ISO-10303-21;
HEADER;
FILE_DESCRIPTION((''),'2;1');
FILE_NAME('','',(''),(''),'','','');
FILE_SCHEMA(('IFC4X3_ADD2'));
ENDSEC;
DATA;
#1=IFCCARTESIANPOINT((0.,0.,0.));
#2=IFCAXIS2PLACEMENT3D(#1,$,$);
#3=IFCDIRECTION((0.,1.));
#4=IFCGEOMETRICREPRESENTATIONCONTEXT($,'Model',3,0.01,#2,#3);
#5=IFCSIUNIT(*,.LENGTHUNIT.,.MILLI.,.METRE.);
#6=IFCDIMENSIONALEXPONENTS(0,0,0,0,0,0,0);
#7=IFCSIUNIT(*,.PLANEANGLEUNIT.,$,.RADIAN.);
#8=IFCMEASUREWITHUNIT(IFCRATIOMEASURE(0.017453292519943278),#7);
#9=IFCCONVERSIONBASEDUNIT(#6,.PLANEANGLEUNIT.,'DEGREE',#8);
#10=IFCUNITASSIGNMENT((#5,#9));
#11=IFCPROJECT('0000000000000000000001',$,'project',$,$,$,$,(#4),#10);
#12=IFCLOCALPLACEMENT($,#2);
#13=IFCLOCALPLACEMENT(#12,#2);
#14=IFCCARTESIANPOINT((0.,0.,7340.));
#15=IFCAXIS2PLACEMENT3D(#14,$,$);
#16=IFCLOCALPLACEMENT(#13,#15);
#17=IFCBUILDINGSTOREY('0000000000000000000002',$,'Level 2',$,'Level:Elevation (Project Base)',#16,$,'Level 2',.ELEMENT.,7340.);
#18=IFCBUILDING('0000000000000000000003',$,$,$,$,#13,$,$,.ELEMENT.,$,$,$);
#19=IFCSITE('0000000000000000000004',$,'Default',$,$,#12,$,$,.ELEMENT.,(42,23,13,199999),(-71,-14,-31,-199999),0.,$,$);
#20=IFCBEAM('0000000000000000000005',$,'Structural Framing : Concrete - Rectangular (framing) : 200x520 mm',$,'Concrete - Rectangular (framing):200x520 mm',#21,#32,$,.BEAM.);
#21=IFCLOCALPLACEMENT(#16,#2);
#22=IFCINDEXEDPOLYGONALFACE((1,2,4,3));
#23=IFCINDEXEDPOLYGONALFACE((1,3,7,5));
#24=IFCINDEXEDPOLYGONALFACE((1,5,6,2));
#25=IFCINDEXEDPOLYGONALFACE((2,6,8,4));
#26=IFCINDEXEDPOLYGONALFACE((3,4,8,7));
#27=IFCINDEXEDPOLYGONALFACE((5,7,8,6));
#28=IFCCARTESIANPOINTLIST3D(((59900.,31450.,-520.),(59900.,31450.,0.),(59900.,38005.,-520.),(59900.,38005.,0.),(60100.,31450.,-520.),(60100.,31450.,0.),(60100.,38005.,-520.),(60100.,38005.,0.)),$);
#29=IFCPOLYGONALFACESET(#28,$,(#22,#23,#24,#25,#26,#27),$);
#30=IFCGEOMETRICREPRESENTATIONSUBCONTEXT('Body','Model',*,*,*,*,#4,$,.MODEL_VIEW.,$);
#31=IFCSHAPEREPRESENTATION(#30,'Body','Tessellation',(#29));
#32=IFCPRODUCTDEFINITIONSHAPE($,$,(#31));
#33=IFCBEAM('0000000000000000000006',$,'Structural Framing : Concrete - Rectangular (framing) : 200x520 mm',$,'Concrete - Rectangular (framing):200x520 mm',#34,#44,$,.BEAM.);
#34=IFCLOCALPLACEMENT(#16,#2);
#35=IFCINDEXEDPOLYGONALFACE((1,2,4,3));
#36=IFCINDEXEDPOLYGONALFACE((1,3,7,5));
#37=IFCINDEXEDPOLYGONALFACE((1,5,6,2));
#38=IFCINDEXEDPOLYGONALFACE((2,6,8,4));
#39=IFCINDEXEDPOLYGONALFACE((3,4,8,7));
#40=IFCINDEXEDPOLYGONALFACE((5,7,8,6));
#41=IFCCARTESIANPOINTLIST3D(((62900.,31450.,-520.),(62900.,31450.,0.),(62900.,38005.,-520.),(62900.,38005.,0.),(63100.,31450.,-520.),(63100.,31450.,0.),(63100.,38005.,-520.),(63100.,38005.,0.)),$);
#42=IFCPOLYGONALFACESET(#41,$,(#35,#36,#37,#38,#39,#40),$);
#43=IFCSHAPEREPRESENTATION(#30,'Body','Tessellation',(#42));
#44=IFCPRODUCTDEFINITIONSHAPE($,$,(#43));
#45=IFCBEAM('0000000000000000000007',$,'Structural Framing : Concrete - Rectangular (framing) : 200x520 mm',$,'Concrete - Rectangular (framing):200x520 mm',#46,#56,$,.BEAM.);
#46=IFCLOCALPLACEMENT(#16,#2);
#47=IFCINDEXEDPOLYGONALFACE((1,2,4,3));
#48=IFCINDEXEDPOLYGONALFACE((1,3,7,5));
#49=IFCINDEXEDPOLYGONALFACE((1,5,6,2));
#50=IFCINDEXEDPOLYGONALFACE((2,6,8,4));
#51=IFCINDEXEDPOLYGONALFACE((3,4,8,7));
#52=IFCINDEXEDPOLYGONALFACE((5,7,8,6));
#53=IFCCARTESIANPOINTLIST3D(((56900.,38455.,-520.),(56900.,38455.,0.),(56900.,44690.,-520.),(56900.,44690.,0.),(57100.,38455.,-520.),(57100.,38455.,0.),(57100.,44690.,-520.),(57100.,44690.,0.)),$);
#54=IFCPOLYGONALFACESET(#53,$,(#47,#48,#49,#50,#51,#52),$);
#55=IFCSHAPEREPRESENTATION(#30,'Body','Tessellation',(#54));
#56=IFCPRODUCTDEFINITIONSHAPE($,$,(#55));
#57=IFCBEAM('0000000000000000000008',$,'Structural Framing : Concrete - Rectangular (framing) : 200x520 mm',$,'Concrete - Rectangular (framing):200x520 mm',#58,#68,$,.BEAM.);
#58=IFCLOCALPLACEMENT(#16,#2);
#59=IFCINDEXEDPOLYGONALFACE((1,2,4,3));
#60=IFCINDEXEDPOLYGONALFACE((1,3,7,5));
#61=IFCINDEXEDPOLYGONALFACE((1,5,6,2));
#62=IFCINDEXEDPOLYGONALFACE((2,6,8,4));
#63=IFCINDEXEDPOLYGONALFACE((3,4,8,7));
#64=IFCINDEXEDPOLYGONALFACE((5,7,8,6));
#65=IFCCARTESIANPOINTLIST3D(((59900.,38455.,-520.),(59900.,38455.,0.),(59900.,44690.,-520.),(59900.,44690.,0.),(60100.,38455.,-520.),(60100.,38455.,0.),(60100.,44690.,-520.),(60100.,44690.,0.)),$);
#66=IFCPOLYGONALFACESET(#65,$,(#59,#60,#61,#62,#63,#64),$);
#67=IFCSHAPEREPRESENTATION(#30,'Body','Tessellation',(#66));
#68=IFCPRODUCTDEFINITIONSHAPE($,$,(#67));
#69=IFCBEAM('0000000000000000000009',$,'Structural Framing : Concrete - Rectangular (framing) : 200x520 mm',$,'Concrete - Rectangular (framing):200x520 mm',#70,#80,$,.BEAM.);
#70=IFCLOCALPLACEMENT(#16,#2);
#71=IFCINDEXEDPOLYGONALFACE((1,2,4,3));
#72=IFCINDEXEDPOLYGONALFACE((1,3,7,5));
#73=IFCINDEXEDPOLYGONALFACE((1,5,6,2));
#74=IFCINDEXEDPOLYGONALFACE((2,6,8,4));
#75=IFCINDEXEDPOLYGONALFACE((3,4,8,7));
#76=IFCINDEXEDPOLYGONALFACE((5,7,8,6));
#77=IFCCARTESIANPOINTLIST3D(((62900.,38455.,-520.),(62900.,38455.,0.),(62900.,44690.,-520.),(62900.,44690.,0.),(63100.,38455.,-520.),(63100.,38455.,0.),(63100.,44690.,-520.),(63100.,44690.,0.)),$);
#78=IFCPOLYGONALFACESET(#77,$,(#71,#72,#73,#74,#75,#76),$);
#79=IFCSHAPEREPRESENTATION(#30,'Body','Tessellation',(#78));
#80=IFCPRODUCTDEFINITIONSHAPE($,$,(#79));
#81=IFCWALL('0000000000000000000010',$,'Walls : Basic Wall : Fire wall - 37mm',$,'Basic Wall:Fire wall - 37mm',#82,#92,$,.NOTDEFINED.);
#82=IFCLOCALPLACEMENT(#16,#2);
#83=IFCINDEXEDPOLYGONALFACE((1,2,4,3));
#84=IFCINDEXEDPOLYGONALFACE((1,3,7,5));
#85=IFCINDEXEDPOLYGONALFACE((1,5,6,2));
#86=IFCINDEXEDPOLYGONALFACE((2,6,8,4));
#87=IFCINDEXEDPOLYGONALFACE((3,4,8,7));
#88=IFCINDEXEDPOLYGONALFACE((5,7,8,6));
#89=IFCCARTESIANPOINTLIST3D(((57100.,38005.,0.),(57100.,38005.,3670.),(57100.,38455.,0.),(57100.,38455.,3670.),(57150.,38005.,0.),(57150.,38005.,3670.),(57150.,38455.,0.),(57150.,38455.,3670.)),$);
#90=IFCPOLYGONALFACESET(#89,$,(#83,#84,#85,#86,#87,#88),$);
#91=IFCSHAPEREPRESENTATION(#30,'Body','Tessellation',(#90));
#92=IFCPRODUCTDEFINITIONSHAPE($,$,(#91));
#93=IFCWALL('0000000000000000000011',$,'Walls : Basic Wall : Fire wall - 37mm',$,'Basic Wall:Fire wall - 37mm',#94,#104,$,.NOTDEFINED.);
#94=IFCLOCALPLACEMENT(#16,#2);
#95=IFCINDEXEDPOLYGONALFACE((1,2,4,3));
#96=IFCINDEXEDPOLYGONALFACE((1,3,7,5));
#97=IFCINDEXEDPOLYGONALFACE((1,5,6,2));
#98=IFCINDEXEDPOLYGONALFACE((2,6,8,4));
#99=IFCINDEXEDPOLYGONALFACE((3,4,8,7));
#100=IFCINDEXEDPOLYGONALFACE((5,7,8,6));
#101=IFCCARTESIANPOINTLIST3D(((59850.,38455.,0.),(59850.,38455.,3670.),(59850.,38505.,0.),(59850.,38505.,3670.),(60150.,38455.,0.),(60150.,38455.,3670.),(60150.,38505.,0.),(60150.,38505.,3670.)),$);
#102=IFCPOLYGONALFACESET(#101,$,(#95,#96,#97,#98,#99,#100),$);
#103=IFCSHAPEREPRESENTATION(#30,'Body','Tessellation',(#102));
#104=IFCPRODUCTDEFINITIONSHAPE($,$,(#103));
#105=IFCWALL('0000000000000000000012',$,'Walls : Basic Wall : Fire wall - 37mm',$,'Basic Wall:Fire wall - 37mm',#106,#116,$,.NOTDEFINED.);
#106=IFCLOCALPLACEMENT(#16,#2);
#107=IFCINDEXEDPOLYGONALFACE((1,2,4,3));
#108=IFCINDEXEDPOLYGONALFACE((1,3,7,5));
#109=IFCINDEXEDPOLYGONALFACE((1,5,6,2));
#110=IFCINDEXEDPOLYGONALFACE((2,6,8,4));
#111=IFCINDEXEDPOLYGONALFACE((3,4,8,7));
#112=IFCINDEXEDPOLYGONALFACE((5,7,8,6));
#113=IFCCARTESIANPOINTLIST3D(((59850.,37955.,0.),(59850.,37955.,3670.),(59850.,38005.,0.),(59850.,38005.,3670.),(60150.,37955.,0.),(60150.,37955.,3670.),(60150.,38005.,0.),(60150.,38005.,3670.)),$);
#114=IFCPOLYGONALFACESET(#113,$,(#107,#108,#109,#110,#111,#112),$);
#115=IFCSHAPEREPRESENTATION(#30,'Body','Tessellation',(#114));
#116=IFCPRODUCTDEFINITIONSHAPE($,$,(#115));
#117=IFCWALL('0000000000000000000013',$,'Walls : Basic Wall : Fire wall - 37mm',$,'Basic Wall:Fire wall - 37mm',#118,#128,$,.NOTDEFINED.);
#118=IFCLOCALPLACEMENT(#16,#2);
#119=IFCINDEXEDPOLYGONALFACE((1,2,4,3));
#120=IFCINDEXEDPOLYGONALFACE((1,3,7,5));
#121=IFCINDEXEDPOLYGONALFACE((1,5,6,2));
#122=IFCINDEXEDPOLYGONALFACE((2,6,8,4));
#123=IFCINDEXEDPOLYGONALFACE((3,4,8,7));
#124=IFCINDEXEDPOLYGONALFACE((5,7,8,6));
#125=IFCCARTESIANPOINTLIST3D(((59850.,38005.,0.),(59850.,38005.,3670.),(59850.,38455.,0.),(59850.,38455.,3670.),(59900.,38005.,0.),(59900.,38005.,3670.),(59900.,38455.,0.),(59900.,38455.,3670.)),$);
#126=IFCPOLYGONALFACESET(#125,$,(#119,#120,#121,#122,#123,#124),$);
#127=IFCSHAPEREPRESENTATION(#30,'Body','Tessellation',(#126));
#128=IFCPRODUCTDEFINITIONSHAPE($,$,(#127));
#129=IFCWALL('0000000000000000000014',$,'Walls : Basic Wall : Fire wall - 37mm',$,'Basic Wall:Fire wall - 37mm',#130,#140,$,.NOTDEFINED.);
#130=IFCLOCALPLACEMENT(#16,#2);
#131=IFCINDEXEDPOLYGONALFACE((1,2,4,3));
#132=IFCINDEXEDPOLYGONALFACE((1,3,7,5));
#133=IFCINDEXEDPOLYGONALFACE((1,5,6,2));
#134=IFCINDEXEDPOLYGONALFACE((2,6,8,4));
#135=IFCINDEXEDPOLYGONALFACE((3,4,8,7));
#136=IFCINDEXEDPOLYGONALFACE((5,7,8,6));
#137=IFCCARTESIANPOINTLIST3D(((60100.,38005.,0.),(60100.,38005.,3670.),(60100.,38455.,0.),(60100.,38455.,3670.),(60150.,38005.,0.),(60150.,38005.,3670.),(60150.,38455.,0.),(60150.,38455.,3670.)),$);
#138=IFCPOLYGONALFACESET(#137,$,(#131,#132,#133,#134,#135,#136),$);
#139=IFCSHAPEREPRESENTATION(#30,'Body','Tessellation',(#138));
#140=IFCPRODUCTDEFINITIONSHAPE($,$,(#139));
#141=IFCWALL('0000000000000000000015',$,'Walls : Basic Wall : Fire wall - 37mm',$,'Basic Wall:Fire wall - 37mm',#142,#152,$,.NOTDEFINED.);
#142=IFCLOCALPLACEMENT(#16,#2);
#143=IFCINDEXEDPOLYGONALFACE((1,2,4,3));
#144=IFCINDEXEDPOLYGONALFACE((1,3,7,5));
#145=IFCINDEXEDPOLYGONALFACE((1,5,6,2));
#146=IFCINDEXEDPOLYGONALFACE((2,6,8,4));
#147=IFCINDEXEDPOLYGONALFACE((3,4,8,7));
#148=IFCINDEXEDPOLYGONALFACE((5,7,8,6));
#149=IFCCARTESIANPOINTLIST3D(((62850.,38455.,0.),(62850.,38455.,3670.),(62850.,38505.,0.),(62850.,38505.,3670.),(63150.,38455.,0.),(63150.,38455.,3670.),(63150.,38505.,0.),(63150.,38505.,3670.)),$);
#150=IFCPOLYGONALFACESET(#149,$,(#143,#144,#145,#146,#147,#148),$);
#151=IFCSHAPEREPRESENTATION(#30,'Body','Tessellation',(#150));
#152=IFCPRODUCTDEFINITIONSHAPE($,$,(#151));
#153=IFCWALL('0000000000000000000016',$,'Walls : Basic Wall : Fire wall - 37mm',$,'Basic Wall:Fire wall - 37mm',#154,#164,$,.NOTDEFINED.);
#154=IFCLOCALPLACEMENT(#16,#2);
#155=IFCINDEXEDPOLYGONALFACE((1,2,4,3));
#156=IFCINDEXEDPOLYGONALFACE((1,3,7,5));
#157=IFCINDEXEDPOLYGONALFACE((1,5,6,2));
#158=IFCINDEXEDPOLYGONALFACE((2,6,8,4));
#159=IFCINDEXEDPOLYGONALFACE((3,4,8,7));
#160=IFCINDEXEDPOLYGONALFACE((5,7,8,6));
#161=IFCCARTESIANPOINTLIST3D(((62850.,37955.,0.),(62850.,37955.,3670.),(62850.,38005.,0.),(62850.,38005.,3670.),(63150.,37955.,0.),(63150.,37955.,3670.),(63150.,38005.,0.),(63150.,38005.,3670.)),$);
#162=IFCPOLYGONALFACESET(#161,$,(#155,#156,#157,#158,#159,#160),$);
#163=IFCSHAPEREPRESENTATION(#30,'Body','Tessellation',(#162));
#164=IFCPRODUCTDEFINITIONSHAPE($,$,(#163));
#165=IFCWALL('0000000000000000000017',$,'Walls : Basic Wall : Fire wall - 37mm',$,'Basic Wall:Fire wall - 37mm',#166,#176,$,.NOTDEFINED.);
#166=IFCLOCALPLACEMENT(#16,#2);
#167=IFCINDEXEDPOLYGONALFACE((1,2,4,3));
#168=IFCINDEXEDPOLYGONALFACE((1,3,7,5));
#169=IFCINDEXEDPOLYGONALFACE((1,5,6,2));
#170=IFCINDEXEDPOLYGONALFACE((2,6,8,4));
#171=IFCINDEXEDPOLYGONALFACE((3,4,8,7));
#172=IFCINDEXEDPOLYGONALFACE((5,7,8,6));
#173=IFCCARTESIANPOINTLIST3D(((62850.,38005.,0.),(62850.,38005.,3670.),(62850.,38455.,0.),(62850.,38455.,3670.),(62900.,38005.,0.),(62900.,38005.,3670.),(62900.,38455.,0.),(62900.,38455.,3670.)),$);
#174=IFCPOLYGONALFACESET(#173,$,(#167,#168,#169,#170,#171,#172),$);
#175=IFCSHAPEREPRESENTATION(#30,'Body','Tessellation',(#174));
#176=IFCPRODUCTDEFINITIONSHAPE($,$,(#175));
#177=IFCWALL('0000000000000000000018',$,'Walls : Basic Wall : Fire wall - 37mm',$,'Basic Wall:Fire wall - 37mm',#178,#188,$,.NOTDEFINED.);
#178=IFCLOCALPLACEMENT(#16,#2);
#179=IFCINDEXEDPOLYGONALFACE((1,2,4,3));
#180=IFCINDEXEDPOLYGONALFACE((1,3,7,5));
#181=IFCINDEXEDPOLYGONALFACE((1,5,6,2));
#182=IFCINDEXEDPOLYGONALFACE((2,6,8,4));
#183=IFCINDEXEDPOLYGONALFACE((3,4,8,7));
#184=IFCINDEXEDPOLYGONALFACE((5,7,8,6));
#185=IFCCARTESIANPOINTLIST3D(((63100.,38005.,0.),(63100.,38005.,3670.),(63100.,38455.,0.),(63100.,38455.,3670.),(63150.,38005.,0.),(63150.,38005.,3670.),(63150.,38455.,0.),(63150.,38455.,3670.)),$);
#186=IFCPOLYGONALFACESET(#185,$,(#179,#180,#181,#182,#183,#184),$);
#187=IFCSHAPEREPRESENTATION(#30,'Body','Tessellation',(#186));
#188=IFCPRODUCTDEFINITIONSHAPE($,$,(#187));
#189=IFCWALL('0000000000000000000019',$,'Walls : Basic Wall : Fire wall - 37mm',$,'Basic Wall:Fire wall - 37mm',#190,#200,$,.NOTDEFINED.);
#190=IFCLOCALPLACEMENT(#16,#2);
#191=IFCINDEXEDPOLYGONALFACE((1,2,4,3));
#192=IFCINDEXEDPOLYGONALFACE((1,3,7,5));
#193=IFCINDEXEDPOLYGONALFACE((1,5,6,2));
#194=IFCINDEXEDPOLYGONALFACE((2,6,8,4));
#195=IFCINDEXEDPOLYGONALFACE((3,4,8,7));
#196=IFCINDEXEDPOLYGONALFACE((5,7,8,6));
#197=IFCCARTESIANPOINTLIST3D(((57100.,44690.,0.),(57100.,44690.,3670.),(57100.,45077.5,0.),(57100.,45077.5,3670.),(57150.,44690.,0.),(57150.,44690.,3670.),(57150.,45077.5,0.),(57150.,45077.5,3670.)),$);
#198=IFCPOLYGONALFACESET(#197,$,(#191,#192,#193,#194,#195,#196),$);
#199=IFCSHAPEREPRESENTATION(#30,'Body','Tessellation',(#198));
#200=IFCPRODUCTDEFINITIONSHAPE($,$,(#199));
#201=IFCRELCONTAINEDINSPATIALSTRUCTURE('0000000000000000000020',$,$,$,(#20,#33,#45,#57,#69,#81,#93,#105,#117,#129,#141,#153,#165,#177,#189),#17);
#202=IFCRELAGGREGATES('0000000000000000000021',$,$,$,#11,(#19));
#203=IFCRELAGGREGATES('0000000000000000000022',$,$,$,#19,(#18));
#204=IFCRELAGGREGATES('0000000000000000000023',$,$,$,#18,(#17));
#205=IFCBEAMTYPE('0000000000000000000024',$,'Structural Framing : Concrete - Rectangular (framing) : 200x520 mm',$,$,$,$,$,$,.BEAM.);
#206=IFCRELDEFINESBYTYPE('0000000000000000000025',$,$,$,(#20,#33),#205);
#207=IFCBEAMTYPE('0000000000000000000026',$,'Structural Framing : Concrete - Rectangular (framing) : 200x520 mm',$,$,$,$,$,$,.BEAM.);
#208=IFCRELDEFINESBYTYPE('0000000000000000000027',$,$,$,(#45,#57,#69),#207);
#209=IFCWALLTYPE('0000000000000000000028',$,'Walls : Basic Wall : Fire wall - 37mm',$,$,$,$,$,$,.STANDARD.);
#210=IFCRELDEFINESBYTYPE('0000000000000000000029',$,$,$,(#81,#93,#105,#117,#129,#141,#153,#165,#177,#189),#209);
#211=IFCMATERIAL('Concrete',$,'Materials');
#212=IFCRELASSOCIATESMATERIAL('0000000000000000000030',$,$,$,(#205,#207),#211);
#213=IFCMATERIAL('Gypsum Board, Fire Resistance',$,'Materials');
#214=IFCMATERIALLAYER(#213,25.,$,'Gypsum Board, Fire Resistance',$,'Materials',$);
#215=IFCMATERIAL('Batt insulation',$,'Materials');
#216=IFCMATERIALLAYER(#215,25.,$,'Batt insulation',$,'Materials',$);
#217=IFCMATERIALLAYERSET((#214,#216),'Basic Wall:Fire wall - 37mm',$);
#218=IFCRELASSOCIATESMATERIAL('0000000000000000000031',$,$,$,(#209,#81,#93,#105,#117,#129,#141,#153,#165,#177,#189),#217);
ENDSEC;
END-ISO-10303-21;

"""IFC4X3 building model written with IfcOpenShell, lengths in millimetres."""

from ifc_helpers import new_model, entity, si_unit, converted_unit, direction, frame, frame_2d, origin, place, context, subcontext, project, spatial, rectangle, extrude, source, transform, mapped, material, layer, layer_set, material_profile, profile_set, type_object, type_shapes, element, save


model = new_model("IFC4X3")

# Units and contexts
model_context = context("Model", 3, precision=0.01, world=origin(), true_north=direction((0.0, 1.0)))
body_context = subcontext(model_context, "Body", "Model", "MODEL_VIEW")
ifc_project = project(units=[si_unit("LENGTHUNIT", "METRE", prefix="MILLI"), converted_unit("PLANEANGLEUNIT", "DEGREE", entity("IfcRatioMeasure", 0.017453292519943278), si_unit("PLANEANGLEUNIT", "RADIAN"), dimensions=[0, 0, 0, 0, 0, 0, 0])], contexts=[model_context])

# Site, building, storey
site_placement = place(None, origin())
site = spatial("IfcSite", under=ifc_project, at=site_placement, Name="Default", CompositionType="ELEMENT", RefLatitude=(42, 23, 13, 199999), RefLongitude=(-71, -14, -31, -199999), RefElevation=0.0)
building_placement = place(site_placement, origin())
building = spatial("IfcBuilding", under=site, at=building_placement, CompositionType="ELEMENT")
storey_placement = place(building_placement, frame((0.0, 0.0, 7340.0)))
storey = spatial("IfcBuildingStorey", under=building, at=storey_placement, Name="Level 2", ObjectType="Level:Elevation (Project Base)", LongName="Level 2", CompositionType="ELEMENT", Elevation=7340.0)

# Beams
ifc_material_1 = material(Name="Concrete", Category="Materials")
ifc_material_profile = material_profile(ifc_material_1, rectangle(XDim=520.0, YDim=200.0, at=frame_2d((0.0, 0.0), x_axis=(1.0, 0.0))), Name="200x520 mm")
ifc_profile_set = profile_set([ifc_material_profile], Name="200x520 mm")
beam_type_1 = type_object("IfcBeamType", Name="Structural Framing : Concrete - Rectangular (framing) : 200x520 mm", PredefinedType="BEAM", material=ifc_profile_set)
shared_shape_1 = source(origin(), body_context, "Body", "SweptSolid", [
    extrude(rectangle(XDim=520.0, YDim=200.0, at=frame_2d((0.0, 0.0), x_axis=(1.0, 0.0))), frame((-1165.0, 0.0, 0.0), z_axis=(1.0, 0.0, 0.0), x_axis=(0.0, 0.0, -1.0)), (0.0, 0.0, 1.0), 6555.0),
])
type_shapes(beam_type_1, [shared_shape_1])
for number, where, z_axis, x_axis, name in (
    (1, (60000.0, 36840.0, -260.0), (0.0, 0.0, 1.0), (0.0, -1.0, 0.0), "Structural Framing : Concrete - Rectangular (framing) : 200x520 mm"),
    (2, (63000.0, 36840.0, -260.0), (0.0, 0.0, 1.0), (0.0, -1.0, 0.0), "Structural Framing : Concrete - Rectangular (framing) : 200x520 mm"),
):
    element("IfcBeam", number, at=place(storey_placement, frame(where, z_axis=z_axis, x_axis=x_axis)), inside=storey, type_object=beam_type_1, Name=name, ObjectType="Concrete - Rectangular (framing):200x520 mm", PredefinedType="BEAM", context=body_context, shape_type="MappedRepresentation", body=[
        mapped(shared_shape_1, transform((0.0, 0.0, 0.0), scale=1.0)),
    ])
beam_type_2 = type_object("IfcBeamType", Name="Structural Framing : Concrete - Rectangular (framing) : 200x520 mm", PredefinedType="BEAM", material=ifc_profile_set)
shared_shape_2 = source(origin(), body_context, "Body", "SweptSolid", [
    extrude(rectangle(XDim=520.0, YDim=200.0, at=frame_2d((0.0, 0.0), x_axis=(1.0, 0.0))), frame((-1350.0, 0.0, 0.0), z_axis=(1.0, 0.0, 0.0), x_axis=(0.0, 0.0, -1.0)), (0.0, 0.0, 1.0), 6235.0),
])
type_shapes(beam_type_2, [shared_shape_2])
for number, where, z_axis, x_axis, name in (
    (3, (57000.0, 43340.0, -260.0), (0.0, 0.0, 1.0), (0.0, -1.0, 0.0), "Structural Framing : Concrete - Rectangular (framing) : 200x520 mm"),
    (4, (60000.0, 43340.0, -260.0), (0.0, 0.0, 1.0), (0.0, -1.0, 0.0), "Structural Framing : Concrete - Rectangular (framing) : 200x520 mm"),
    (5, (63000.0, 43340.0, -260.0), (0.0, 0.0, 1.0), (0.0, -1.0, 0.0), "Structural Framing : Concrete - Rectangular (framing) : 200x520 mm"),
):
    element("IfcBeam", number, at=place(storey_placement, frame(where, z_axis=z_axis, x_axis=x_axis)), inside=storey, type_object=beam_type_2, Name=name, ObjectType="Concrete - Rectangular (framing):200x520 mm", PredefinedType="BEAM", context=body_context, shape_type="MappedRepresentation", body=[
        mapped(shared_shape_2, transform((0.0, 0.0, 0.0), scale=1.0)),
    ])

# Walls
ifc_material_2 = material(Name="Gypsum Board, Fire Resistance", Category="Materials")
ifc_layer_1 = layer(ifc_material_2, 25.0, Name="Gypsum Board, Fire Resistance", Category="Materials")
ifc_material_3 = material(Name="Batt insulation", Category="Materials")
ifc_layer_2 = layer(ifc_material_3, 25.0, Name="Batt insulation", Category="Materials")
ifc_layer_set = layer_set([ifc_layer_1, ifc_layer_2], Name="Basic Wall:Fire wall - 37mm")
wall_type = type_object("IfcWallType", Name="Walls : Basic Wall : Fire wall - 37mm", PredefinedType="STANDARD", material=ifc_layer_set)
wall_1_placement = place(storey_placement, frame((57125.0, 38455.0, 0.0), z_axis=(0.0, 0.0, 1.0), x_axis=(0.0, -1.0, 0.0)))
element("IfcWall", 6, at=wall_1_placement, inside=storey, type_object=wall_type, material=ifc_layer_set, Name="Walls : Basic Wall : Fire wall - 37mm", ObjectType="Basic Wall:Fire wall - 37mm", PredefinedType="NOTDEFINED", context=body_context, shape_type="SweptSolid", body=[
    extrude(rectangle(XDim=450.0, YDim=50.0, at=frame_2d((225.0, 0.0), x_axis=(-1.0, 0.0))), origin(), (0.0, 0.0, 1.0), 3670.0),
])
for number, where, name in (
    (7, (59850.0, 38480.0, 0.0), "Walls : Basic Wall : Fire wall - 37mm"),
    (8, (59850.0, 37980.0, 0.0), "Walls : Basic Wall : Fire wall - 37mm"),
):
    element("IfcWall", number, at=place(storey_placement, frame(where)), inside=storey, type_object=wall_type, material=ifc_layer_set, Name=name, ObjectType="Basic Wall:Fire wall - 37mm", PredefinedType="NOTDEFINED", context=body_context, shape_type="SweptSolid", body=[
        extrude(rectangle(XDim=300.0, YDim=50.0, at=frame_2d((150.0, 0.0), x_axis=(-1.0, 0.0))), origin(), (0.0, 0.0, 1.0), 3670.0),
    ])
for number, where, z_axis, x_axis, name in (
    (9, (59875.0, 38455.0, 0.0), (0.0, 0.0, 1.0), (0.0, -1.0, 0.0), "Walls : Basic Wall : Fire wall - 37mm"),
    (10, (60125.0, 38455.0, 0.0), (0.0, 0.0, 1.0), (0.0, -1.0, 0.0), "Walls : Basic Wall : Fire wall - 37mm"),
):
    element("IfcWall", number, at=place(storey_placement, frame(where, z_axis=z_axis, x_axis=x_axis)), inside=storey, type_object=wall_type, material=ifc_layer_set, Name=name, ObjectType="Basic Wall:Fire wall - 37mm", PredefinedType="NOTDEFINED", context=body_context, shape_type="SweptSolid", body=[
        extrude(rectangle(XDim=450.0, YDim=50.0, at=frame_2d((225.0, 0.0), x_axis=(-1.0, 0.0))), origin(), (0.0, 0.0, 1.0), 3670.0),
    ])
for number, where, name in (
    (11, (62850.0, 38480.0, 0.0), "Walls : Basic Wall : Fire wall - 37mm"),
    (12, (62850.0, 37980.0, 0.0), "Walls : Basic Wall : Fire wall - 37mm"),
):
    element("IfcWall", number, at=place(storey_placement, frame(where)), inside=storey, type_object=wall_type, material=ifc_layer_set, Name=name, ObjectType="Basic Wall:Fire wall - 37mm", PredefinedType="NOTDEFINED", context=body_context, shape_type="SweptSolid", body=[
        extrude(rectangle(XDim=300.0, YDim=50.0, at=frame_2d((150.0, 0.0), x_axis=(-1.0, 0.0))), origin(), (0.0, 0.0, 1.0), 3670.0),
    ])
for number, where, z_axis, x_axis, name in (
    (13, (62875.0, 38455.0, 0.0), (0.0, 0.0, 1.0), (0.0, -1.0, 0.0), "Walls : Basic Wall : Fire wall - 37mm"),
    (14, (63125.0, 38455.0, 0.0), (0.0, 0.0, 1.0), (0.0, -1.0, 0.0), "Walls : Basic Wall : Fire wall - 37mm"),
):
    element("IfcWall", number, at=place(storey_placement, frame(where, z_axis=z_axis, x_axis=x_axis)), inside=storey, type_object=wall_type, material=ifc_layer_set, Name=name, ObjectType="Basic Wall:Fire wall - 37mm", PredefinedType="NOTDEFINED", context=body_context, shape_type="SweptSolid", body=[
        extrude(rectangle(XDim=450.0, YDim=50.0, at=frame_2d((225.0, 0.0), x_axis=(-1.0, 0.0))), origin(), (0.0, 0.0, 1.0), 3670.0),
    ])
wall_2_placement = place(storey_placement, frame((57125.0, 45077.5, 0.0), z_axis=(0.0, 0.0, 1.0), x_axis=(0.0, -1.0, 0.0)))
element("IfcWall", 15, at=wall_2_placement, inside=storey, type_object=wall_type, material=ifc_layer_set, Name="Walls : Basic Wall : Fire wall - 37mm", ObjectType="Basic Wall:Fire wall - 37mm", PredefinedType="NOTDEFINED", context=body_context, shape_type="SweptSolid", body=[
    extrude(rectangle(XDim=387.5, YDim=50.0, at=frame_2d((193.7, 0.0), x_axis=(-1.0, 0.0))), origin(), (0.0, 0.0, 1.0), 3670.0),
])

save(model, "model.ifc")
